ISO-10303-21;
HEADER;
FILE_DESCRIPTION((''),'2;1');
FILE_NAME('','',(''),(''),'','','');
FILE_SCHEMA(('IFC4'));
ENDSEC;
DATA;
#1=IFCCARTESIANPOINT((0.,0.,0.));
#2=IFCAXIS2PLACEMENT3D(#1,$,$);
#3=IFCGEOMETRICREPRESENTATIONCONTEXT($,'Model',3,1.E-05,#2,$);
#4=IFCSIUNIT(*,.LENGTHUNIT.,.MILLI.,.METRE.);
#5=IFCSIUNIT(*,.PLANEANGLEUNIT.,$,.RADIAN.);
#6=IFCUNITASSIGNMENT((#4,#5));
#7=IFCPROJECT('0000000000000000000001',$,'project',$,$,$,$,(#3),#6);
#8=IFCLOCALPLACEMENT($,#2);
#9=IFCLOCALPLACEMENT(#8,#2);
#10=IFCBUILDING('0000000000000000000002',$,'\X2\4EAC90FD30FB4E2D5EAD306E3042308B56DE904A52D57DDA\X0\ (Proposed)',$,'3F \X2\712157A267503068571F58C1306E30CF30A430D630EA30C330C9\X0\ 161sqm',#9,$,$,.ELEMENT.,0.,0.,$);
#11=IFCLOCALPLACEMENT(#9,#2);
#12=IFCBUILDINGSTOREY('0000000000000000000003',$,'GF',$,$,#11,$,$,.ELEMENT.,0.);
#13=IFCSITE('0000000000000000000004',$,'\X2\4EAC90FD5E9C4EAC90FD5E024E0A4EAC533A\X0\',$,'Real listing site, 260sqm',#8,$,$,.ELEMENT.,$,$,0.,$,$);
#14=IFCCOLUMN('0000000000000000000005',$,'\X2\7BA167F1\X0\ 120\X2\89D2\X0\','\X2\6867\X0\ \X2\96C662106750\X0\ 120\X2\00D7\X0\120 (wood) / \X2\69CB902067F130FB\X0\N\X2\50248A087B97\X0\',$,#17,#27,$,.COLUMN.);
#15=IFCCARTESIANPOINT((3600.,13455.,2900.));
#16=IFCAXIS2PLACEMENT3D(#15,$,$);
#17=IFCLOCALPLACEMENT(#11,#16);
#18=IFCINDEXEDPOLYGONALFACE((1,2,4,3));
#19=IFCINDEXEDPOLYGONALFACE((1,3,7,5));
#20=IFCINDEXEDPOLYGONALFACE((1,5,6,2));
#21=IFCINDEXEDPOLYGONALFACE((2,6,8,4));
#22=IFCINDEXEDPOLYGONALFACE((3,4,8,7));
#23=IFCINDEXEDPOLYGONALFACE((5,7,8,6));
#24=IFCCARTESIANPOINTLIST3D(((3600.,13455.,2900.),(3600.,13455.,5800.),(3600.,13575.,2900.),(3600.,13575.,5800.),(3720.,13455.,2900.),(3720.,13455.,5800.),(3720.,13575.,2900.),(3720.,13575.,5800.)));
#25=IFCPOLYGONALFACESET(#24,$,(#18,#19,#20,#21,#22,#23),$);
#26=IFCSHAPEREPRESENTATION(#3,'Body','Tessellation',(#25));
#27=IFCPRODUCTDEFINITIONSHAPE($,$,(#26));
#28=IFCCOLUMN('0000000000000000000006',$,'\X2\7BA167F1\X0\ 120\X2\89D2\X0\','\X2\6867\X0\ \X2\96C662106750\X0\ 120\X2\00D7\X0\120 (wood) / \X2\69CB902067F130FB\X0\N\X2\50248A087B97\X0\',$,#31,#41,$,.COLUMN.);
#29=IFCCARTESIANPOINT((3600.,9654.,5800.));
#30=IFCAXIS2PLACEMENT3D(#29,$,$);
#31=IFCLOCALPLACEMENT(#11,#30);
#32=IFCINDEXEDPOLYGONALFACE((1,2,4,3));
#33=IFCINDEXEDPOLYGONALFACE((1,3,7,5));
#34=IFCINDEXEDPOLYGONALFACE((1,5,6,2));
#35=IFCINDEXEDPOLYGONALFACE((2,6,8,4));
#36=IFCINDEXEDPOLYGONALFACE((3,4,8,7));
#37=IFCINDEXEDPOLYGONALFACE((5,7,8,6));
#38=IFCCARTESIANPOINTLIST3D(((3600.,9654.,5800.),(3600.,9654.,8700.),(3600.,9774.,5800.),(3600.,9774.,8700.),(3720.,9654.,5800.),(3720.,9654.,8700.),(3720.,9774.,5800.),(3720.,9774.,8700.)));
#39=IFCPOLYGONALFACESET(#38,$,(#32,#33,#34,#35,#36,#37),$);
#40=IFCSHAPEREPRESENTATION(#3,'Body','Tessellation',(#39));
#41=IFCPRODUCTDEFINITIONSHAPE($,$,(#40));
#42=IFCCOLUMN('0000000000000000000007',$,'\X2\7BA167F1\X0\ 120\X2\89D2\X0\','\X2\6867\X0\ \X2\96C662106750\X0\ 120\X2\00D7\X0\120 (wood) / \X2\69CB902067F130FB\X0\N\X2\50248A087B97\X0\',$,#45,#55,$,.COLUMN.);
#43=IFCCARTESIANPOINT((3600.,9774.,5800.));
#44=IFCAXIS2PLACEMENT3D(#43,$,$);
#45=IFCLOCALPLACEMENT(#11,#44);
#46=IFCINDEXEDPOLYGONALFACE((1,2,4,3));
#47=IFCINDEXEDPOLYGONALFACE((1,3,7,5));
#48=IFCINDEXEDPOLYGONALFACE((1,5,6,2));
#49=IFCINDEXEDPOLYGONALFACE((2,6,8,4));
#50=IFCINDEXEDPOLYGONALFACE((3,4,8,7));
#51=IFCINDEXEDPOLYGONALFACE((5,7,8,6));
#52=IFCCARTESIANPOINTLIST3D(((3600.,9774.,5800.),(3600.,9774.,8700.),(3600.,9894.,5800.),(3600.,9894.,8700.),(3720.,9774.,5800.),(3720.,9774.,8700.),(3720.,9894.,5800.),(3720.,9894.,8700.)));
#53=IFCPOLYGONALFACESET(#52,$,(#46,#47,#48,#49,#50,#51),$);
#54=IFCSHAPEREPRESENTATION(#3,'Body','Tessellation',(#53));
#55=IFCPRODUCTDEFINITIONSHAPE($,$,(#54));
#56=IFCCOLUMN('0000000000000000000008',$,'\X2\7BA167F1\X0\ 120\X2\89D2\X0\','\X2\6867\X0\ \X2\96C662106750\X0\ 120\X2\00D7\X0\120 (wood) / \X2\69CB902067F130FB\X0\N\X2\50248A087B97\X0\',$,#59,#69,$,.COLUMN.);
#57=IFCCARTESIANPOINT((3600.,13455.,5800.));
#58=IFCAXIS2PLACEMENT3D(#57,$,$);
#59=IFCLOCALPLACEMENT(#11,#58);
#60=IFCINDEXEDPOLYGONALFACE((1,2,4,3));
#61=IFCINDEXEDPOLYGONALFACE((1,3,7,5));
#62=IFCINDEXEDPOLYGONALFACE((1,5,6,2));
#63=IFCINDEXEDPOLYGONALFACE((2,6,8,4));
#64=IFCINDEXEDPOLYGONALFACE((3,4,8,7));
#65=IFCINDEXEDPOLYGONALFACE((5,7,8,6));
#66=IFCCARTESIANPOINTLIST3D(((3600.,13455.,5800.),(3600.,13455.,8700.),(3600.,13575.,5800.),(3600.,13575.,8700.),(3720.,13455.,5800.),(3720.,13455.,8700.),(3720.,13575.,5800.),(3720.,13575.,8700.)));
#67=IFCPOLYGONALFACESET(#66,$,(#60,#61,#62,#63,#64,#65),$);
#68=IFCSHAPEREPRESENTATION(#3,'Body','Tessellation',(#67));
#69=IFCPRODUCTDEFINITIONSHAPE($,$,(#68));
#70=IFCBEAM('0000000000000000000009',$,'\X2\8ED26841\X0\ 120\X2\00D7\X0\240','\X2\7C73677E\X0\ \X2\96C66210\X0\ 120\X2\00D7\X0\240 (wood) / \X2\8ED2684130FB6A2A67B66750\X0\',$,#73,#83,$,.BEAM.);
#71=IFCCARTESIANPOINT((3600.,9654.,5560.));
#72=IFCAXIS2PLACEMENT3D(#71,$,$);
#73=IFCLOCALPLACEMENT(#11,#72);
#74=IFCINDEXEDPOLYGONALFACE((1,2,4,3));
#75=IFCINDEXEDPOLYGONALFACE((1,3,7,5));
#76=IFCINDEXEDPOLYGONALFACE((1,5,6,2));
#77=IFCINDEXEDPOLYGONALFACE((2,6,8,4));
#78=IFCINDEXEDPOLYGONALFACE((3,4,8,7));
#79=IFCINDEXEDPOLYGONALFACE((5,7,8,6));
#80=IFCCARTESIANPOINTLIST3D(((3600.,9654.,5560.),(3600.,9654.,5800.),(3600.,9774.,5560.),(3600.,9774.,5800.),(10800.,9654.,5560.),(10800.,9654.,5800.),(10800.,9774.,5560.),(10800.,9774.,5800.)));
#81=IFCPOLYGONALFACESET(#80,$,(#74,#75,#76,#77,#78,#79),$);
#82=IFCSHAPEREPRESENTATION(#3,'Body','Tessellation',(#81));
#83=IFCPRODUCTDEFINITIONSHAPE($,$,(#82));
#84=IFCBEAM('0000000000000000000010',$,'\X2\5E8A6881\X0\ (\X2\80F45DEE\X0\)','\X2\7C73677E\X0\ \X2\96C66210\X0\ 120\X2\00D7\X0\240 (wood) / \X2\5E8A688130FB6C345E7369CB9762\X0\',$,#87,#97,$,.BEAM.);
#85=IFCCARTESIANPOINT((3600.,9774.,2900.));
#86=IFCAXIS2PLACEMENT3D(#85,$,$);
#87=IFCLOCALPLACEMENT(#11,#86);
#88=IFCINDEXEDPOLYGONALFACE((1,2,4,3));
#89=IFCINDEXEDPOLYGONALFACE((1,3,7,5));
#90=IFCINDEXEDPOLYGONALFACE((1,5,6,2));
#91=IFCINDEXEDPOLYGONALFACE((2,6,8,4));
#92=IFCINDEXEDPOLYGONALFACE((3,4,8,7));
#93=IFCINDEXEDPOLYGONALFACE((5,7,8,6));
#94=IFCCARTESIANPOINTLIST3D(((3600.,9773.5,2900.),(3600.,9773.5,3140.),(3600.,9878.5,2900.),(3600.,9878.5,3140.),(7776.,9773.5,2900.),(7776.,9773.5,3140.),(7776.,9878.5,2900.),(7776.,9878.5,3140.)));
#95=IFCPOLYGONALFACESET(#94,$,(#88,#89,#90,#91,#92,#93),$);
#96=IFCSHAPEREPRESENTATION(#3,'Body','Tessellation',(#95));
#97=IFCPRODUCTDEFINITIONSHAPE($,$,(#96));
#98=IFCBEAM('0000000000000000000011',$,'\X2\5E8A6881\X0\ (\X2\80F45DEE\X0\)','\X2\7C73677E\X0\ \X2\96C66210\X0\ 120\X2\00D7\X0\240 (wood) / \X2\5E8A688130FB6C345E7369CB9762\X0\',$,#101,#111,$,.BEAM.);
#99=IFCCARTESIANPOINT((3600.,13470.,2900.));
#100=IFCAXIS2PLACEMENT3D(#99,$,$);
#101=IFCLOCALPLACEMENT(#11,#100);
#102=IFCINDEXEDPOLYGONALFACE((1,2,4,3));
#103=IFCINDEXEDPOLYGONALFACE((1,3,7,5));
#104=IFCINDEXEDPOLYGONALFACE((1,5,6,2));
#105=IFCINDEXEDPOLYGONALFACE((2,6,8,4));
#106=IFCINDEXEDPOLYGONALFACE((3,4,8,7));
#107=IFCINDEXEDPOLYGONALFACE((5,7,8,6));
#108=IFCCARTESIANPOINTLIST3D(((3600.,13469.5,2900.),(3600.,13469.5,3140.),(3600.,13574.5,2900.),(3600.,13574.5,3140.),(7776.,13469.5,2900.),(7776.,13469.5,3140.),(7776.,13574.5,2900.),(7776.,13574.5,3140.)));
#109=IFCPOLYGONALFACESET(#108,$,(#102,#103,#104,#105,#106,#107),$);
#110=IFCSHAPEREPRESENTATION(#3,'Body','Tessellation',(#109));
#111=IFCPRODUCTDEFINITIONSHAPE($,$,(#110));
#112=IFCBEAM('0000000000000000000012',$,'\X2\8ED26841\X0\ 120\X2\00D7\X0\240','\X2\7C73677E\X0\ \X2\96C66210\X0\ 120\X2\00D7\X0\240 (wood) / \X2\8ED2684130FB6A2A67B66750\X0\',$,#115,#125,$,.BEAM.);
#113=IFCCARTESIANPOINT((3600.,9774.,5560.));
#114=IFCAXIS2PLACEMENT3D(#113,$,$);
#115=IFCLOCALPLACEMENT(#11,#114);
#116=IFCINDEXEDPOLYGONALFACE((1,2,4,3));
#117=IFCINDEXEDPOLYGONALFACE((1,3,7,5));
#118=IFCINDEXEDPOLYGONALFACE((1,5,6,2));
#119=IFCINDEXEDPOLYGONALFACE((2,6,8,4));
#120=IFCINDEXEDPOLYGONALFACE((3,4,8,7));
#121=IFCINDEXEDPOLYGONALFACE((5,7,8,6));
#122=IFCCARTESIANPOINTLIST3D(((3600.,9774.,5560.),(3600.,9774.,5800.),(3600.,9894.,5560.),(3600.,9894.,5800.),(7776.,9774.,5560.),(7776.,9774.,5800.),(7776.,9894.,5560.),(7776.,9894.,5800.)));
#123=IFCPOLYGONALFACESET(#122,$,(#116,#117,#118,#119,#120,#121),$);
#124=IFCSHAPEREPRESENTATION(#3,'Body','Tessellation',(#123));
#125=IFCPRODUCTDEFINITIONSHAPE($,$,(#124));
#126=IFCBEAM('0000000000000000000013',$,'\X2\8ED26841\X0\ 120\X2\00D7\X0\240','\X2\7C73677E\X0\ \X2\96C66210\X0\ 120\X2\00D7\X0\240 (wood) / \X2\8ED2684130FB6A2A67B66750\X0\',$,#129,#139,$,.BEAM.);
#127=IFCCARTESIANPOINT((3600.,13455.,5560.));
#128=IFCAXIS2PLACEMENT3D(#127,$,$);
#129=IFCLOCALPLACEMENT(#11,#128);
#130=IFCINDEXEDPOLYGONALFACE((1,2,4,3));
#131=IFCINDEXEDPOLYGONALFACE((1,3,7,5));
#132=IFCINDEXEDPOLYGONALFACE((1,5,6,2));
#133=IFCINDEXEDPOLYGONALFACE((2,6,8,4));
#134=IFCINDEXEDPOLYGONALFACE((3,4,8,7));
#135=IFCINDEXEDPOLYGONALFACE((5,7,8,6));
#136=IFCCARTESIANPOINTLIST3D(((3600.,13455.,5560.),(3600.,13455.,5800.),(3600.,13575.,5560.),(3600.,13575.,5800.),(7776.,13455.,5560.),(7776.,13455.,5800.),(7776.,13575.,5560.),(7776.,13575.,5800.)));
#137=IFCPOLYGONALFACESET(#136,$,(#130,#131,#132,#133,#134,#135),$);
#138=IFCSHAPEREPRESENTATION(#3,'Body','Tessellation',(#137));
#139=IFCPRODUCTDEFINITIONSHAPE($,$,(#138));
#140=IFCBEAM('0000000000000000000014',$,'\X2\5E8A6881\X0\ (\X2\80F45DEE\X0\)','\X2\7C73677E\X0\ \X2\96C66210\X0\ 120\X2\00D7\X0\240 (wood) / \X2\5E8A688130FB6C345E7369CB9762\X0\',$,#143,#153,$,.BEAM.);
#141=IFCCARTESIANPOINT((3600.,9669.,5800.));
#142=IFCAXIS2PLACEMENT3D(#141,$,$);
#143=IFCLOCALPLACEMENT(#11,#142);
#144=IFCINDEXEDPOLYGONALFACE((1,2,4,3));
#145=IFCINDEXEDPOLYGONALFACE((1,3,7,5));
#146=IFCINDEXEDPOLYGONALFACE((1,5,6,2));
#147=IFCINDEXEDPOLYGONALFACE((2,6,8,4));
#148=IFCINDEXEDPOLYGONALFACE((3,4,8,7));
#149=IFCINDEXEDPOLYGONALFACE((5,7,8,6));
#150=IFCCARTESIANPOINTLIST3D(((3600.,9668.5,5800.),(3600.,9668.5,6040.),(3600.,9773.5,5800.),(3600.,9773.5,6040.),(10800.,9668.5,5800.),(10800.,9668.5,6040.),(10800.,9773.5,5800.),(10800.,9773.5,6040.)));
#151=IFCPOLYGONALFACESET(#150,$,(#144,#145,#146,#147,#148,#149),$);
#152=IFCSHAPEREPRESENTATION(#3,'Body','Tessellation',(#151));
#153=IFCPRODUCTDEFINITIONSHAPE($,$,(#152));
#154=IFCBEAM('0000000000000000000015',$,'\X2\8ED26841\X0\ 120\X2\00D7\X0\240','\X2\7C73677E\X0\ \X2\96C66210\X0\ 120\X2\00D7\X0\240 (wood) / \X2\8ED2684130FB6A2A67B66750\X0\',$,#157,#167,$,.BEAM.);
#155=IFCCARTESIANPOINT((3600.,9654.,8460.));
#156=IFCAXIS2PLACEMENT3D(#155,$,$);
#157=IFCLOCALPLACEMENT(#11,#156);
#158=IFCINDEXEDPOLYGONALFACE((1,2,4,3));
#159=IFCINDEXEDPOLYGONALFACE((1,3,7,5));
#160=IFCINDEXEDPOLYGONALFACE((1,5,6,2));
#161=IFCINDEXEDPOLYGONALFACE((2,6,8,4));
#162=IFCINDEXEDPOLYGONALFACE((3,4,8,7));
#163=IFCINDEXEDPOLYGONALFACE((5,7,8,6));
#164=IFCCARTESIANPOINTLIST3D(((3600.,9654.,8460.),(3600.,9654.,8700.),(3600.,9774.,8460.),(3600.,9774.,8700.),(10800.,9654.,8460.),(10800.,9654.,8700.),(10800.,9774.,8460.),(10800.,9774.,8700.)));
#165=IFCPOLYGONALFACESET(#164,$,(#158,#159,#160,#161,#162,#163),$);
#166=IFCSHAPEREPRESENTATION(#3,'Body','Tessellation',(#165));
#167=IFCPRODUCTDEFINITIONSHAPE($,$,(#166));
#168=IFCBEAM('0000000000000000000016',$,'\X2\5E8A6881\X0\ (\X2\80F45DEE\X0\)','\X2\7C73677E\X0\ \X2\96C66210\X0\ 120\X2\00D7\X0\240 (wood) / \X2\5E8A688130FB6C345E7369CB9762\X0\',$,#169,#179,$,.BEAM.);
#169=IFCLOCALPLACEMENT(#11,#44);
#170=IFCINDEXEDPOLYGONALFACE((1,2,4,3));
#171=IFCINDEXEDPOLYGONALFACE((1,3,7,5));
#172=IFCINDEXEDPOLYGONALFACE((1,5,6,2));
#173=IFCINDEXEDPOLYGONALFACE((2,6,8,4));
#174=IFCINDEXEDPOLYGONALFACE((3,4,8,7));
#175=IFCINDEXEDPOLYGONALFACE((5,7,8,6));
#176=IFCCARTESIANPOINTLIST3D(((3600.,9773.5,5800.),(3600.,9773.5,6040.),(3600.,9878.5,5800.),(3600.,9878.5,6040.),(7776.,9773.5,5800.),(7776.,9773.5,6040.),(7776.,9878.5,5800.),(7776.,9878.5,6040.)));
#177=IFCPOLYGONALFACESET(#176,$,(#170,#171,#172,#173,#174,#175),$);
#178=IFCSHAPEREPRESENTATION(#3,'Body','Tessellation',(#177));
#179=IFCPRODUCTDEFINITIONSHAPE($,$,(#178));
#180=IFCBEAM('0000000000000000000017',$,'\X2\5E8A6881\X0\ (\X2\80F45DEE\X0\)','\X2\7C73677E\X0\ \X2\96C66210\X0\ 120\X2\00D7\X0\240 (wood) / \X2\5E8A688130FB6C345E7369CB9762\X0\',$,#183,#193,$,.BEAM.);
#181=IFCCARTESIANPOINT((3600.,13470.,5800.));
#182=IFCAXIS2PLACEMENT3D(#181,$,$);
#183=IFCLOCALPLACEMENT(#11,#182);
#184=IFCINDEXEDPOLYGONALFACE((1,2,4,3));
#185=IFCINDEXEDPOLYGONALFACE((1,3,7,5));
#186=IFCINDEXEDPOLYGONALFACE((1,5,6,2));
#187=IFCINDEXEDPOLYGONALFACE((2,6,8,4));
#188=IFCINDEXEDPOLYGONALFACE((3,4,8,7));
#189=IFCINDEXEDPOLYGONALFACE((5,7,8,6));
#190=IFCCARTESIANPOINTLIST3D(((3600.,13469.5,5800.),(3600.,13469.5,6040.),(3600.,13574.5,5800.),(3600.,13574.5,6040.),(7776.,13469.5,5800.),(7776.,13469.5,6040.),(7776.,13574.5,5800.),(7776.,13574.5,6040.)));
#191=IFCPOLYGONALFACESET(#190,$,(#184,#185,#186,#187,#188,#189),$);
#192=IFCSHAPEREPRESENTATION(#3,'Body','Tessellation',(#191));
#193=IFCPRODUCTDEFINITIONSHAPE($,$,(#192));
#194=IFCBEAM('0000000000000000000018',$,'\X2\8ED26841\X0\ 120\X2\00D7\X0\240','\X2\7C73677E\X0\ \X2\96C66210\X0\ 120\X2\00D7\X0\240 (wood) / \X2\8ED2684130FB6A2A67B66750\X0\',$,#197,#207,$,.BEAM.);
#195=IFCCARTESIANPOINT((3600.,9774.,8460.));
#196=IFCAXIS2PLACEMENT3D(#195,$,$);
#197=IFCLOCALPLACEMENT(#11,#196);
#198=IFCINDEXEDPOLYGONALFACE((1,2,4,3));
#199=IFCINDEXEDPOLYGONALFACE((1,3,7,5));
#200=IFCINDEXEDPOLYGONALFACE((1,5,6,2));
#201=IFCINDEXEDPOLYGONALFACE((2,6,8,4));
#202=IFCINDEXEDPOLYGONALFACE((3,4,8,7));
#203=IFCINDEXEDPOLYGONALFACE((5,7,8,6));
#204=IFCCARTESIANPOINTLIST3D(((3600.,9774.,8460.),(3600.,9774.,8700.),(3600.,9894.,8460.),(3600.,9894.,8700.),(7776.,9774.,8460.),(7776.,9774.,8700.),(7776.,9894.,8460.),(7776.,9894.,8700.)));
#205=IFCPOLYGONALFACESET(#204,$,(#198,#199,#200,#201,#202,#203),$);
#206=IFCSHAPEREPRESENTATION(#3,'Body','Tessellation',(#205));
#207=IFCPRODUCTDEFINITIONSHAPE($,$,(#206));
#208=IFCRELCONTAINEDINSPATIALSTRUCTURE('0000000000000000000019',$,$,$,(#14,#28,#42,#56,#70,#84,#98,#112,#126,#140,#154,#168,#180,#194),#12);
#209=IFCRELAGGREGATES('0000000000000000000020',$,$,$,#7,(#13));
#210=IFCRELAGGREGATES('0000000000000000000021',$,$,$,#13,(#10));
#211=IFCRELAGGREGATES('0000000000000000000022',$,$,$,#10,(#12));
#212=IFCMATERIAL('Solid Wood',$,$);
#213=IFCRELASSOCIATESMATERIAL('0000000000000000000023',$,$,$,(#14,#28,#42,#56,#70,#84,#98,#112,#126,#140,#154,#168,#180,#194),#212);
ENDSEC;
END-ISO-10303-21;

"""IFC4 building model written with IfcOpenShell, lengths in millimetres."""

from ifc_helpers import new_model, si_unit, frame, frame_2d, origin, place, context, project, spatial, rectangle, extrude, material, element, save


model = new_model("IFC4")

# Units and contexts
model_context = context("Model", 3, precision=1e-05, world=origin())
ifc_project = project(units=[si_unit("LENGTHUNIT", "METRE", prefix="MILLI"), si_unit("PLANEANGLEUNIT", "RADIAN")], contexts=[model_context])

# Site, building, storey
site_placement = place(None, origin())
site = spatial("IfcSite", under=ifc_project, at=site_placement, Name="京都府京都市上京区", ObjectType="Real listing site, 260sqm", CompositionType="ELEMENT", RefElevation=0.0)
building_placement = place(site_placement, origin())
building = spatial("IfcBuilding", under=site, at=building_placement, Name="京都・中庭のある回遊動線 (Proposed)", ObjectType="3F 無垢材と土壁のハイブリッド 161sqm", CompositionType="ELEMENT", ElevationOfRefHeight=0.0, ElevationOfTerrain=0.0)
storey_placement = place(building_placement, origin())
storey = spatial("IfcBuildingStorey", under=building, at=storey_placement, Name="GF", CompositionType="ELEMENT", Elevation=0.0)

# Columns
ifc_material_1 = material(Name="Solid Wood")
column_1_placement = place(storey_placement, frame((3600.0, 13455.0, 2900.0)))
element("IfcColumn", 1, at=column_1_placement, inside=storey, material=ifc_material_1, Name="管柱 120角", Description="桧 集成材 120×120 (wood) / 構造柱・N値計算", PredefinedType="COLUMN", context=model_context, shape_type="SweptSolid", body=[
    extrude(rectangle(XDim=120.0, YDim=120.0, at=frame_2d((60.0, 60.0))), frame((3600.0, 13455.0, 2900.0)), (0.0, 0.0, 1.0), 2900.0),
])
column_2_placement = place(storey_placement, frame((3600.0, 9654.0, 5800.0)))
element("IfcColumn", 2, at=column_2_placement, inside=storey, material=ifc_material_1, Name="管柱 120角", Description="桧 集成材 120×120 (wood) / 構造柱・N値計算", PredefinedType="COLUMN", context=model_context, shape_type="SweptSolid", body=[
    extrude(rectangle(XDim=120.0, YDim=120.0, at=frame_2d((60.0, 60.0))), frame((3600.0, 9654.0, 5800.0)), (0.0, 0.0, 1.0), 2900.0),
])
column_3_placement = place(storey_placement, frame((3600.0, 9774.0, 5800.0)))
element("IfcColumn", 3, at=column_3_placement, inside=storey, material=ifc_material_1, Name="管柱 120角", Description="桧 集成材 120×120 (wood) / 構造柱・N値計算", PredefinedType="COLUMN", context=model_context, shape_type="SweptSolid", body=[
    extrude(rectangle(XDim=120.0, YDim=120.0, at=frame_2d((60.0, 60.0))), frame((3600.0, 9774.0, 5800.0)), (0.0, 0.0, 1.0), 2900.0),
])
column_4_placement = place(storey_placement, frame((3600.0, 13455.0, 5800.0)))
element("IfcColumn", 4, at=column_4_placement, inside=storey, material=ifc_material_1, Name="管柱 120角", Description="桧 集成材 120×120 (wood) / 構造柱・N値計算", PredefinedType="COLUMN", context=model_context, shape_type="SweptSolid", body=[
    extrude(rectangle(XDim=120.0, YDim=120.0, at=frame_2d((60.0, 60.0))), frame((3600.0, 13455.0, 5800.0)), (0.0, 0.0, 1.0), 2900.0),
])

# Beams
beam_1_placement = place(storey_placement, frame((3600.0, 9654.0, 5560.0)))
element("IfcBeam", 5, at=beam_1_placement, inside=storey, material=ifc_material_1, Name="軒桁 120×240", Description="米松 集成 120×240 (wood) / 軒桁・横架材", PredefinedType="BEAM", context=model_context, shape_type="SweptSolid", body=[
    extrude(rectangle(XDim=7200.0, YDim=120.0, at=frame_2d((3600.0, 60.0))), frame((3600.0, 9654.0, 5560.0)), (0.0, 0.0, 1.0), 240.0),
])
beam_2_placement = place(storey_placement, frame((3600.0, 9774.0, 2900.0)))
element("IfcBeam", 6, at=beam_2_placement, inside=storey, material=ifc_material_1, Name="床梁 (胴差)", Description="米松 集成 120×240 (wood) / 床梁・水平構面", PredefinedType="BEAM", context=model_context, shape_type="SweptSolid", body=[
    extrude(rectangle(XDim=4176.0, YDim=105.0, at=frame_2d((2088.0, 52.0))), frame((3600.0, 9774.0, 2900.0)), (0.0, 0.0, 1.0), 240.0),
])
beam_3_placement = place(storey_placement, frame((3600.0, 13470.0, 2900.0)))
element("IfcBeam", 7, at=beam_3_placement, inside=storey, material=ifc_material_1, Name="床梁 (胴差)", Description="米松 集成 120×240 (wood) / 床梁・水平構面", PredefinedType="BEAM", context=model_context, shape_type="SweptSolid", body=[
    extrude(rectangle(XDim=4176.0, YDim=105.0, at=frame_2d((2088.0, 52.0))), frame((3600.0, 13470.0, 2900.0)), (0.0, 0.0, 1.0), 240.0),
])
beam_4_placement = place(storey_placement, frame((3600.0, 9774.0, 5560.0)))
element("IfcBeam", 8, at=beam_4_placement, inside=storey, material=ifc_material_1, Name="軒桁 120×240", Description="米松 集成 120×240 (wood) / 軒桁・横架材", PredefinedType="BEAM", context=model_context, shape_type="SweptSolid", body=[
    extrude(rectangle(XDim=4176.0, YDim=120.0, at=frame_2d((2088.0, 60.0))), frame((3600.0, 9774.0, 5560.0)), (0.0, 0.0, 1.0), 240.0),
])
beam_5_placement = place(storey_placement, frame((3600.0, 13455.0, 5560.0)))
element("IfcBeam", 9, at=beam_5_placement, inside=storey, material=ifc_material_1, Name="軒桁 120×240", Description="米松 集成 120×240 (wood) / 軒桁・横架材", PredefinedType="BEAM", context=model_context, shape_type="SweptSolid", body=[
    extrude(rectangle(XDim=4176.0, YDim=120.0, at=frame_2d((2088.0, 60.0))), frame((3600.0, 13455.0, 5560.0)), (0.0, 0.0, 1.0), 240.0),
])
beam_6_placement = place(storey_placement, frame((3600.0, 9669.0, 5800.0)))
element("IfcBeam", 10, at=beam_6_placement, inside=storey, material=ifc_material_1, Name="床梁 (胴差)", Description="米松 集成 120×240 (wood) / 床梁・水平構面", PredefinedType="BEAM", context=model_context, shape_type="SweptSolid", body=[
    extrude(rectangle(XDim=7200.0, YDim=105.0, at=frame_2d((3600.0, 52.0))), frame((3600.0, 9669.0, 5800.0)), (0.0, 0.0, 1.0), 240.0),
])
beam_7_placement = place(storey_placement, frame((3600.0, 9654.0, 8460.0)))
element("IfcBeam", 11, at=beam_7_placement, inside=storey, material=ifc_material_1, Name="軒桁 120×240", Description="米松 集成 120×240 (wood) / 軒桁・横架材", PredefinedType="BEAM", context=model_context, shape_type="SweptSolid", body=[
    extrude(rectangle(XDim=7200.0, YDim=120.0, at=frame_2d((3600.0, 60.0))), frame((3600.0, 9654.0, 8460.0)), (0.0, 0.0, 1.0), 240.0),
])
beam_8_placement = place(storey_placement, frame((3600.0, 9774.0, 5800.0)))
element("IfcBeam", 12, at=beam_8_placement, inside=storey, material=ifc_material_1, Name="床梁 (胴差)", Description="米松 集成 120×240 (wood) / 床梁・水平構面", PredefinedType="BEAM", context=model_context, shape_type="SweptSolid", body=[
    extrude(rectangle(XDim=4176.0, YDim=105.0, at=frame_2d((2088.0, 52.0))), frame((3600.0, 9774.0, 5800.0)), (0.0, 0.0, 1.0), 240.0),
])
beam_9_placement = place(storey_placement, frame((3600.0, 13470.0, 5800.0)))
element("IfcBeam", 13, at=beam_9_placement, inside=storey, material=ifc_material_1, Name="床梁 (胴差)", Description="米松 集成 120×240 (wood) / 床梁・水平構面", PredefinedType="BEAM", context=model_context, shape_type="SweptSolid", body=[
    extrude(rectangle(XDim=4176.0, YDim=105.0, at=frame_2d((2088.0, 52.0))), frame((3600.0, 13470.0, 5800.0)), (0.0, 0.0, 1.0), 240.0),
])
beam_10_placement = place(storey_placement, frame((3600.0, 9774.0, 8460.0)))
element("IfcBeam", 14, at=beam_10_placement, inside=storey, material=ifc_material_1, Name="軒桁 120×240", Description="米松 集成 120×240 (wood) / 軒桁・横架材", PredefinedType="BEAM", context=model_context, shape_type="SweptSolid", body=[
    extrude(rectangle(XDim=4176.0, YDim=120.0, at=frame_2d((2088.0, 60.0))), frame((3600.0, 9774.0, 8460.0)), (0.0, 0.0, 1.0), 240.0),
])

save(model, "model.ifc")
